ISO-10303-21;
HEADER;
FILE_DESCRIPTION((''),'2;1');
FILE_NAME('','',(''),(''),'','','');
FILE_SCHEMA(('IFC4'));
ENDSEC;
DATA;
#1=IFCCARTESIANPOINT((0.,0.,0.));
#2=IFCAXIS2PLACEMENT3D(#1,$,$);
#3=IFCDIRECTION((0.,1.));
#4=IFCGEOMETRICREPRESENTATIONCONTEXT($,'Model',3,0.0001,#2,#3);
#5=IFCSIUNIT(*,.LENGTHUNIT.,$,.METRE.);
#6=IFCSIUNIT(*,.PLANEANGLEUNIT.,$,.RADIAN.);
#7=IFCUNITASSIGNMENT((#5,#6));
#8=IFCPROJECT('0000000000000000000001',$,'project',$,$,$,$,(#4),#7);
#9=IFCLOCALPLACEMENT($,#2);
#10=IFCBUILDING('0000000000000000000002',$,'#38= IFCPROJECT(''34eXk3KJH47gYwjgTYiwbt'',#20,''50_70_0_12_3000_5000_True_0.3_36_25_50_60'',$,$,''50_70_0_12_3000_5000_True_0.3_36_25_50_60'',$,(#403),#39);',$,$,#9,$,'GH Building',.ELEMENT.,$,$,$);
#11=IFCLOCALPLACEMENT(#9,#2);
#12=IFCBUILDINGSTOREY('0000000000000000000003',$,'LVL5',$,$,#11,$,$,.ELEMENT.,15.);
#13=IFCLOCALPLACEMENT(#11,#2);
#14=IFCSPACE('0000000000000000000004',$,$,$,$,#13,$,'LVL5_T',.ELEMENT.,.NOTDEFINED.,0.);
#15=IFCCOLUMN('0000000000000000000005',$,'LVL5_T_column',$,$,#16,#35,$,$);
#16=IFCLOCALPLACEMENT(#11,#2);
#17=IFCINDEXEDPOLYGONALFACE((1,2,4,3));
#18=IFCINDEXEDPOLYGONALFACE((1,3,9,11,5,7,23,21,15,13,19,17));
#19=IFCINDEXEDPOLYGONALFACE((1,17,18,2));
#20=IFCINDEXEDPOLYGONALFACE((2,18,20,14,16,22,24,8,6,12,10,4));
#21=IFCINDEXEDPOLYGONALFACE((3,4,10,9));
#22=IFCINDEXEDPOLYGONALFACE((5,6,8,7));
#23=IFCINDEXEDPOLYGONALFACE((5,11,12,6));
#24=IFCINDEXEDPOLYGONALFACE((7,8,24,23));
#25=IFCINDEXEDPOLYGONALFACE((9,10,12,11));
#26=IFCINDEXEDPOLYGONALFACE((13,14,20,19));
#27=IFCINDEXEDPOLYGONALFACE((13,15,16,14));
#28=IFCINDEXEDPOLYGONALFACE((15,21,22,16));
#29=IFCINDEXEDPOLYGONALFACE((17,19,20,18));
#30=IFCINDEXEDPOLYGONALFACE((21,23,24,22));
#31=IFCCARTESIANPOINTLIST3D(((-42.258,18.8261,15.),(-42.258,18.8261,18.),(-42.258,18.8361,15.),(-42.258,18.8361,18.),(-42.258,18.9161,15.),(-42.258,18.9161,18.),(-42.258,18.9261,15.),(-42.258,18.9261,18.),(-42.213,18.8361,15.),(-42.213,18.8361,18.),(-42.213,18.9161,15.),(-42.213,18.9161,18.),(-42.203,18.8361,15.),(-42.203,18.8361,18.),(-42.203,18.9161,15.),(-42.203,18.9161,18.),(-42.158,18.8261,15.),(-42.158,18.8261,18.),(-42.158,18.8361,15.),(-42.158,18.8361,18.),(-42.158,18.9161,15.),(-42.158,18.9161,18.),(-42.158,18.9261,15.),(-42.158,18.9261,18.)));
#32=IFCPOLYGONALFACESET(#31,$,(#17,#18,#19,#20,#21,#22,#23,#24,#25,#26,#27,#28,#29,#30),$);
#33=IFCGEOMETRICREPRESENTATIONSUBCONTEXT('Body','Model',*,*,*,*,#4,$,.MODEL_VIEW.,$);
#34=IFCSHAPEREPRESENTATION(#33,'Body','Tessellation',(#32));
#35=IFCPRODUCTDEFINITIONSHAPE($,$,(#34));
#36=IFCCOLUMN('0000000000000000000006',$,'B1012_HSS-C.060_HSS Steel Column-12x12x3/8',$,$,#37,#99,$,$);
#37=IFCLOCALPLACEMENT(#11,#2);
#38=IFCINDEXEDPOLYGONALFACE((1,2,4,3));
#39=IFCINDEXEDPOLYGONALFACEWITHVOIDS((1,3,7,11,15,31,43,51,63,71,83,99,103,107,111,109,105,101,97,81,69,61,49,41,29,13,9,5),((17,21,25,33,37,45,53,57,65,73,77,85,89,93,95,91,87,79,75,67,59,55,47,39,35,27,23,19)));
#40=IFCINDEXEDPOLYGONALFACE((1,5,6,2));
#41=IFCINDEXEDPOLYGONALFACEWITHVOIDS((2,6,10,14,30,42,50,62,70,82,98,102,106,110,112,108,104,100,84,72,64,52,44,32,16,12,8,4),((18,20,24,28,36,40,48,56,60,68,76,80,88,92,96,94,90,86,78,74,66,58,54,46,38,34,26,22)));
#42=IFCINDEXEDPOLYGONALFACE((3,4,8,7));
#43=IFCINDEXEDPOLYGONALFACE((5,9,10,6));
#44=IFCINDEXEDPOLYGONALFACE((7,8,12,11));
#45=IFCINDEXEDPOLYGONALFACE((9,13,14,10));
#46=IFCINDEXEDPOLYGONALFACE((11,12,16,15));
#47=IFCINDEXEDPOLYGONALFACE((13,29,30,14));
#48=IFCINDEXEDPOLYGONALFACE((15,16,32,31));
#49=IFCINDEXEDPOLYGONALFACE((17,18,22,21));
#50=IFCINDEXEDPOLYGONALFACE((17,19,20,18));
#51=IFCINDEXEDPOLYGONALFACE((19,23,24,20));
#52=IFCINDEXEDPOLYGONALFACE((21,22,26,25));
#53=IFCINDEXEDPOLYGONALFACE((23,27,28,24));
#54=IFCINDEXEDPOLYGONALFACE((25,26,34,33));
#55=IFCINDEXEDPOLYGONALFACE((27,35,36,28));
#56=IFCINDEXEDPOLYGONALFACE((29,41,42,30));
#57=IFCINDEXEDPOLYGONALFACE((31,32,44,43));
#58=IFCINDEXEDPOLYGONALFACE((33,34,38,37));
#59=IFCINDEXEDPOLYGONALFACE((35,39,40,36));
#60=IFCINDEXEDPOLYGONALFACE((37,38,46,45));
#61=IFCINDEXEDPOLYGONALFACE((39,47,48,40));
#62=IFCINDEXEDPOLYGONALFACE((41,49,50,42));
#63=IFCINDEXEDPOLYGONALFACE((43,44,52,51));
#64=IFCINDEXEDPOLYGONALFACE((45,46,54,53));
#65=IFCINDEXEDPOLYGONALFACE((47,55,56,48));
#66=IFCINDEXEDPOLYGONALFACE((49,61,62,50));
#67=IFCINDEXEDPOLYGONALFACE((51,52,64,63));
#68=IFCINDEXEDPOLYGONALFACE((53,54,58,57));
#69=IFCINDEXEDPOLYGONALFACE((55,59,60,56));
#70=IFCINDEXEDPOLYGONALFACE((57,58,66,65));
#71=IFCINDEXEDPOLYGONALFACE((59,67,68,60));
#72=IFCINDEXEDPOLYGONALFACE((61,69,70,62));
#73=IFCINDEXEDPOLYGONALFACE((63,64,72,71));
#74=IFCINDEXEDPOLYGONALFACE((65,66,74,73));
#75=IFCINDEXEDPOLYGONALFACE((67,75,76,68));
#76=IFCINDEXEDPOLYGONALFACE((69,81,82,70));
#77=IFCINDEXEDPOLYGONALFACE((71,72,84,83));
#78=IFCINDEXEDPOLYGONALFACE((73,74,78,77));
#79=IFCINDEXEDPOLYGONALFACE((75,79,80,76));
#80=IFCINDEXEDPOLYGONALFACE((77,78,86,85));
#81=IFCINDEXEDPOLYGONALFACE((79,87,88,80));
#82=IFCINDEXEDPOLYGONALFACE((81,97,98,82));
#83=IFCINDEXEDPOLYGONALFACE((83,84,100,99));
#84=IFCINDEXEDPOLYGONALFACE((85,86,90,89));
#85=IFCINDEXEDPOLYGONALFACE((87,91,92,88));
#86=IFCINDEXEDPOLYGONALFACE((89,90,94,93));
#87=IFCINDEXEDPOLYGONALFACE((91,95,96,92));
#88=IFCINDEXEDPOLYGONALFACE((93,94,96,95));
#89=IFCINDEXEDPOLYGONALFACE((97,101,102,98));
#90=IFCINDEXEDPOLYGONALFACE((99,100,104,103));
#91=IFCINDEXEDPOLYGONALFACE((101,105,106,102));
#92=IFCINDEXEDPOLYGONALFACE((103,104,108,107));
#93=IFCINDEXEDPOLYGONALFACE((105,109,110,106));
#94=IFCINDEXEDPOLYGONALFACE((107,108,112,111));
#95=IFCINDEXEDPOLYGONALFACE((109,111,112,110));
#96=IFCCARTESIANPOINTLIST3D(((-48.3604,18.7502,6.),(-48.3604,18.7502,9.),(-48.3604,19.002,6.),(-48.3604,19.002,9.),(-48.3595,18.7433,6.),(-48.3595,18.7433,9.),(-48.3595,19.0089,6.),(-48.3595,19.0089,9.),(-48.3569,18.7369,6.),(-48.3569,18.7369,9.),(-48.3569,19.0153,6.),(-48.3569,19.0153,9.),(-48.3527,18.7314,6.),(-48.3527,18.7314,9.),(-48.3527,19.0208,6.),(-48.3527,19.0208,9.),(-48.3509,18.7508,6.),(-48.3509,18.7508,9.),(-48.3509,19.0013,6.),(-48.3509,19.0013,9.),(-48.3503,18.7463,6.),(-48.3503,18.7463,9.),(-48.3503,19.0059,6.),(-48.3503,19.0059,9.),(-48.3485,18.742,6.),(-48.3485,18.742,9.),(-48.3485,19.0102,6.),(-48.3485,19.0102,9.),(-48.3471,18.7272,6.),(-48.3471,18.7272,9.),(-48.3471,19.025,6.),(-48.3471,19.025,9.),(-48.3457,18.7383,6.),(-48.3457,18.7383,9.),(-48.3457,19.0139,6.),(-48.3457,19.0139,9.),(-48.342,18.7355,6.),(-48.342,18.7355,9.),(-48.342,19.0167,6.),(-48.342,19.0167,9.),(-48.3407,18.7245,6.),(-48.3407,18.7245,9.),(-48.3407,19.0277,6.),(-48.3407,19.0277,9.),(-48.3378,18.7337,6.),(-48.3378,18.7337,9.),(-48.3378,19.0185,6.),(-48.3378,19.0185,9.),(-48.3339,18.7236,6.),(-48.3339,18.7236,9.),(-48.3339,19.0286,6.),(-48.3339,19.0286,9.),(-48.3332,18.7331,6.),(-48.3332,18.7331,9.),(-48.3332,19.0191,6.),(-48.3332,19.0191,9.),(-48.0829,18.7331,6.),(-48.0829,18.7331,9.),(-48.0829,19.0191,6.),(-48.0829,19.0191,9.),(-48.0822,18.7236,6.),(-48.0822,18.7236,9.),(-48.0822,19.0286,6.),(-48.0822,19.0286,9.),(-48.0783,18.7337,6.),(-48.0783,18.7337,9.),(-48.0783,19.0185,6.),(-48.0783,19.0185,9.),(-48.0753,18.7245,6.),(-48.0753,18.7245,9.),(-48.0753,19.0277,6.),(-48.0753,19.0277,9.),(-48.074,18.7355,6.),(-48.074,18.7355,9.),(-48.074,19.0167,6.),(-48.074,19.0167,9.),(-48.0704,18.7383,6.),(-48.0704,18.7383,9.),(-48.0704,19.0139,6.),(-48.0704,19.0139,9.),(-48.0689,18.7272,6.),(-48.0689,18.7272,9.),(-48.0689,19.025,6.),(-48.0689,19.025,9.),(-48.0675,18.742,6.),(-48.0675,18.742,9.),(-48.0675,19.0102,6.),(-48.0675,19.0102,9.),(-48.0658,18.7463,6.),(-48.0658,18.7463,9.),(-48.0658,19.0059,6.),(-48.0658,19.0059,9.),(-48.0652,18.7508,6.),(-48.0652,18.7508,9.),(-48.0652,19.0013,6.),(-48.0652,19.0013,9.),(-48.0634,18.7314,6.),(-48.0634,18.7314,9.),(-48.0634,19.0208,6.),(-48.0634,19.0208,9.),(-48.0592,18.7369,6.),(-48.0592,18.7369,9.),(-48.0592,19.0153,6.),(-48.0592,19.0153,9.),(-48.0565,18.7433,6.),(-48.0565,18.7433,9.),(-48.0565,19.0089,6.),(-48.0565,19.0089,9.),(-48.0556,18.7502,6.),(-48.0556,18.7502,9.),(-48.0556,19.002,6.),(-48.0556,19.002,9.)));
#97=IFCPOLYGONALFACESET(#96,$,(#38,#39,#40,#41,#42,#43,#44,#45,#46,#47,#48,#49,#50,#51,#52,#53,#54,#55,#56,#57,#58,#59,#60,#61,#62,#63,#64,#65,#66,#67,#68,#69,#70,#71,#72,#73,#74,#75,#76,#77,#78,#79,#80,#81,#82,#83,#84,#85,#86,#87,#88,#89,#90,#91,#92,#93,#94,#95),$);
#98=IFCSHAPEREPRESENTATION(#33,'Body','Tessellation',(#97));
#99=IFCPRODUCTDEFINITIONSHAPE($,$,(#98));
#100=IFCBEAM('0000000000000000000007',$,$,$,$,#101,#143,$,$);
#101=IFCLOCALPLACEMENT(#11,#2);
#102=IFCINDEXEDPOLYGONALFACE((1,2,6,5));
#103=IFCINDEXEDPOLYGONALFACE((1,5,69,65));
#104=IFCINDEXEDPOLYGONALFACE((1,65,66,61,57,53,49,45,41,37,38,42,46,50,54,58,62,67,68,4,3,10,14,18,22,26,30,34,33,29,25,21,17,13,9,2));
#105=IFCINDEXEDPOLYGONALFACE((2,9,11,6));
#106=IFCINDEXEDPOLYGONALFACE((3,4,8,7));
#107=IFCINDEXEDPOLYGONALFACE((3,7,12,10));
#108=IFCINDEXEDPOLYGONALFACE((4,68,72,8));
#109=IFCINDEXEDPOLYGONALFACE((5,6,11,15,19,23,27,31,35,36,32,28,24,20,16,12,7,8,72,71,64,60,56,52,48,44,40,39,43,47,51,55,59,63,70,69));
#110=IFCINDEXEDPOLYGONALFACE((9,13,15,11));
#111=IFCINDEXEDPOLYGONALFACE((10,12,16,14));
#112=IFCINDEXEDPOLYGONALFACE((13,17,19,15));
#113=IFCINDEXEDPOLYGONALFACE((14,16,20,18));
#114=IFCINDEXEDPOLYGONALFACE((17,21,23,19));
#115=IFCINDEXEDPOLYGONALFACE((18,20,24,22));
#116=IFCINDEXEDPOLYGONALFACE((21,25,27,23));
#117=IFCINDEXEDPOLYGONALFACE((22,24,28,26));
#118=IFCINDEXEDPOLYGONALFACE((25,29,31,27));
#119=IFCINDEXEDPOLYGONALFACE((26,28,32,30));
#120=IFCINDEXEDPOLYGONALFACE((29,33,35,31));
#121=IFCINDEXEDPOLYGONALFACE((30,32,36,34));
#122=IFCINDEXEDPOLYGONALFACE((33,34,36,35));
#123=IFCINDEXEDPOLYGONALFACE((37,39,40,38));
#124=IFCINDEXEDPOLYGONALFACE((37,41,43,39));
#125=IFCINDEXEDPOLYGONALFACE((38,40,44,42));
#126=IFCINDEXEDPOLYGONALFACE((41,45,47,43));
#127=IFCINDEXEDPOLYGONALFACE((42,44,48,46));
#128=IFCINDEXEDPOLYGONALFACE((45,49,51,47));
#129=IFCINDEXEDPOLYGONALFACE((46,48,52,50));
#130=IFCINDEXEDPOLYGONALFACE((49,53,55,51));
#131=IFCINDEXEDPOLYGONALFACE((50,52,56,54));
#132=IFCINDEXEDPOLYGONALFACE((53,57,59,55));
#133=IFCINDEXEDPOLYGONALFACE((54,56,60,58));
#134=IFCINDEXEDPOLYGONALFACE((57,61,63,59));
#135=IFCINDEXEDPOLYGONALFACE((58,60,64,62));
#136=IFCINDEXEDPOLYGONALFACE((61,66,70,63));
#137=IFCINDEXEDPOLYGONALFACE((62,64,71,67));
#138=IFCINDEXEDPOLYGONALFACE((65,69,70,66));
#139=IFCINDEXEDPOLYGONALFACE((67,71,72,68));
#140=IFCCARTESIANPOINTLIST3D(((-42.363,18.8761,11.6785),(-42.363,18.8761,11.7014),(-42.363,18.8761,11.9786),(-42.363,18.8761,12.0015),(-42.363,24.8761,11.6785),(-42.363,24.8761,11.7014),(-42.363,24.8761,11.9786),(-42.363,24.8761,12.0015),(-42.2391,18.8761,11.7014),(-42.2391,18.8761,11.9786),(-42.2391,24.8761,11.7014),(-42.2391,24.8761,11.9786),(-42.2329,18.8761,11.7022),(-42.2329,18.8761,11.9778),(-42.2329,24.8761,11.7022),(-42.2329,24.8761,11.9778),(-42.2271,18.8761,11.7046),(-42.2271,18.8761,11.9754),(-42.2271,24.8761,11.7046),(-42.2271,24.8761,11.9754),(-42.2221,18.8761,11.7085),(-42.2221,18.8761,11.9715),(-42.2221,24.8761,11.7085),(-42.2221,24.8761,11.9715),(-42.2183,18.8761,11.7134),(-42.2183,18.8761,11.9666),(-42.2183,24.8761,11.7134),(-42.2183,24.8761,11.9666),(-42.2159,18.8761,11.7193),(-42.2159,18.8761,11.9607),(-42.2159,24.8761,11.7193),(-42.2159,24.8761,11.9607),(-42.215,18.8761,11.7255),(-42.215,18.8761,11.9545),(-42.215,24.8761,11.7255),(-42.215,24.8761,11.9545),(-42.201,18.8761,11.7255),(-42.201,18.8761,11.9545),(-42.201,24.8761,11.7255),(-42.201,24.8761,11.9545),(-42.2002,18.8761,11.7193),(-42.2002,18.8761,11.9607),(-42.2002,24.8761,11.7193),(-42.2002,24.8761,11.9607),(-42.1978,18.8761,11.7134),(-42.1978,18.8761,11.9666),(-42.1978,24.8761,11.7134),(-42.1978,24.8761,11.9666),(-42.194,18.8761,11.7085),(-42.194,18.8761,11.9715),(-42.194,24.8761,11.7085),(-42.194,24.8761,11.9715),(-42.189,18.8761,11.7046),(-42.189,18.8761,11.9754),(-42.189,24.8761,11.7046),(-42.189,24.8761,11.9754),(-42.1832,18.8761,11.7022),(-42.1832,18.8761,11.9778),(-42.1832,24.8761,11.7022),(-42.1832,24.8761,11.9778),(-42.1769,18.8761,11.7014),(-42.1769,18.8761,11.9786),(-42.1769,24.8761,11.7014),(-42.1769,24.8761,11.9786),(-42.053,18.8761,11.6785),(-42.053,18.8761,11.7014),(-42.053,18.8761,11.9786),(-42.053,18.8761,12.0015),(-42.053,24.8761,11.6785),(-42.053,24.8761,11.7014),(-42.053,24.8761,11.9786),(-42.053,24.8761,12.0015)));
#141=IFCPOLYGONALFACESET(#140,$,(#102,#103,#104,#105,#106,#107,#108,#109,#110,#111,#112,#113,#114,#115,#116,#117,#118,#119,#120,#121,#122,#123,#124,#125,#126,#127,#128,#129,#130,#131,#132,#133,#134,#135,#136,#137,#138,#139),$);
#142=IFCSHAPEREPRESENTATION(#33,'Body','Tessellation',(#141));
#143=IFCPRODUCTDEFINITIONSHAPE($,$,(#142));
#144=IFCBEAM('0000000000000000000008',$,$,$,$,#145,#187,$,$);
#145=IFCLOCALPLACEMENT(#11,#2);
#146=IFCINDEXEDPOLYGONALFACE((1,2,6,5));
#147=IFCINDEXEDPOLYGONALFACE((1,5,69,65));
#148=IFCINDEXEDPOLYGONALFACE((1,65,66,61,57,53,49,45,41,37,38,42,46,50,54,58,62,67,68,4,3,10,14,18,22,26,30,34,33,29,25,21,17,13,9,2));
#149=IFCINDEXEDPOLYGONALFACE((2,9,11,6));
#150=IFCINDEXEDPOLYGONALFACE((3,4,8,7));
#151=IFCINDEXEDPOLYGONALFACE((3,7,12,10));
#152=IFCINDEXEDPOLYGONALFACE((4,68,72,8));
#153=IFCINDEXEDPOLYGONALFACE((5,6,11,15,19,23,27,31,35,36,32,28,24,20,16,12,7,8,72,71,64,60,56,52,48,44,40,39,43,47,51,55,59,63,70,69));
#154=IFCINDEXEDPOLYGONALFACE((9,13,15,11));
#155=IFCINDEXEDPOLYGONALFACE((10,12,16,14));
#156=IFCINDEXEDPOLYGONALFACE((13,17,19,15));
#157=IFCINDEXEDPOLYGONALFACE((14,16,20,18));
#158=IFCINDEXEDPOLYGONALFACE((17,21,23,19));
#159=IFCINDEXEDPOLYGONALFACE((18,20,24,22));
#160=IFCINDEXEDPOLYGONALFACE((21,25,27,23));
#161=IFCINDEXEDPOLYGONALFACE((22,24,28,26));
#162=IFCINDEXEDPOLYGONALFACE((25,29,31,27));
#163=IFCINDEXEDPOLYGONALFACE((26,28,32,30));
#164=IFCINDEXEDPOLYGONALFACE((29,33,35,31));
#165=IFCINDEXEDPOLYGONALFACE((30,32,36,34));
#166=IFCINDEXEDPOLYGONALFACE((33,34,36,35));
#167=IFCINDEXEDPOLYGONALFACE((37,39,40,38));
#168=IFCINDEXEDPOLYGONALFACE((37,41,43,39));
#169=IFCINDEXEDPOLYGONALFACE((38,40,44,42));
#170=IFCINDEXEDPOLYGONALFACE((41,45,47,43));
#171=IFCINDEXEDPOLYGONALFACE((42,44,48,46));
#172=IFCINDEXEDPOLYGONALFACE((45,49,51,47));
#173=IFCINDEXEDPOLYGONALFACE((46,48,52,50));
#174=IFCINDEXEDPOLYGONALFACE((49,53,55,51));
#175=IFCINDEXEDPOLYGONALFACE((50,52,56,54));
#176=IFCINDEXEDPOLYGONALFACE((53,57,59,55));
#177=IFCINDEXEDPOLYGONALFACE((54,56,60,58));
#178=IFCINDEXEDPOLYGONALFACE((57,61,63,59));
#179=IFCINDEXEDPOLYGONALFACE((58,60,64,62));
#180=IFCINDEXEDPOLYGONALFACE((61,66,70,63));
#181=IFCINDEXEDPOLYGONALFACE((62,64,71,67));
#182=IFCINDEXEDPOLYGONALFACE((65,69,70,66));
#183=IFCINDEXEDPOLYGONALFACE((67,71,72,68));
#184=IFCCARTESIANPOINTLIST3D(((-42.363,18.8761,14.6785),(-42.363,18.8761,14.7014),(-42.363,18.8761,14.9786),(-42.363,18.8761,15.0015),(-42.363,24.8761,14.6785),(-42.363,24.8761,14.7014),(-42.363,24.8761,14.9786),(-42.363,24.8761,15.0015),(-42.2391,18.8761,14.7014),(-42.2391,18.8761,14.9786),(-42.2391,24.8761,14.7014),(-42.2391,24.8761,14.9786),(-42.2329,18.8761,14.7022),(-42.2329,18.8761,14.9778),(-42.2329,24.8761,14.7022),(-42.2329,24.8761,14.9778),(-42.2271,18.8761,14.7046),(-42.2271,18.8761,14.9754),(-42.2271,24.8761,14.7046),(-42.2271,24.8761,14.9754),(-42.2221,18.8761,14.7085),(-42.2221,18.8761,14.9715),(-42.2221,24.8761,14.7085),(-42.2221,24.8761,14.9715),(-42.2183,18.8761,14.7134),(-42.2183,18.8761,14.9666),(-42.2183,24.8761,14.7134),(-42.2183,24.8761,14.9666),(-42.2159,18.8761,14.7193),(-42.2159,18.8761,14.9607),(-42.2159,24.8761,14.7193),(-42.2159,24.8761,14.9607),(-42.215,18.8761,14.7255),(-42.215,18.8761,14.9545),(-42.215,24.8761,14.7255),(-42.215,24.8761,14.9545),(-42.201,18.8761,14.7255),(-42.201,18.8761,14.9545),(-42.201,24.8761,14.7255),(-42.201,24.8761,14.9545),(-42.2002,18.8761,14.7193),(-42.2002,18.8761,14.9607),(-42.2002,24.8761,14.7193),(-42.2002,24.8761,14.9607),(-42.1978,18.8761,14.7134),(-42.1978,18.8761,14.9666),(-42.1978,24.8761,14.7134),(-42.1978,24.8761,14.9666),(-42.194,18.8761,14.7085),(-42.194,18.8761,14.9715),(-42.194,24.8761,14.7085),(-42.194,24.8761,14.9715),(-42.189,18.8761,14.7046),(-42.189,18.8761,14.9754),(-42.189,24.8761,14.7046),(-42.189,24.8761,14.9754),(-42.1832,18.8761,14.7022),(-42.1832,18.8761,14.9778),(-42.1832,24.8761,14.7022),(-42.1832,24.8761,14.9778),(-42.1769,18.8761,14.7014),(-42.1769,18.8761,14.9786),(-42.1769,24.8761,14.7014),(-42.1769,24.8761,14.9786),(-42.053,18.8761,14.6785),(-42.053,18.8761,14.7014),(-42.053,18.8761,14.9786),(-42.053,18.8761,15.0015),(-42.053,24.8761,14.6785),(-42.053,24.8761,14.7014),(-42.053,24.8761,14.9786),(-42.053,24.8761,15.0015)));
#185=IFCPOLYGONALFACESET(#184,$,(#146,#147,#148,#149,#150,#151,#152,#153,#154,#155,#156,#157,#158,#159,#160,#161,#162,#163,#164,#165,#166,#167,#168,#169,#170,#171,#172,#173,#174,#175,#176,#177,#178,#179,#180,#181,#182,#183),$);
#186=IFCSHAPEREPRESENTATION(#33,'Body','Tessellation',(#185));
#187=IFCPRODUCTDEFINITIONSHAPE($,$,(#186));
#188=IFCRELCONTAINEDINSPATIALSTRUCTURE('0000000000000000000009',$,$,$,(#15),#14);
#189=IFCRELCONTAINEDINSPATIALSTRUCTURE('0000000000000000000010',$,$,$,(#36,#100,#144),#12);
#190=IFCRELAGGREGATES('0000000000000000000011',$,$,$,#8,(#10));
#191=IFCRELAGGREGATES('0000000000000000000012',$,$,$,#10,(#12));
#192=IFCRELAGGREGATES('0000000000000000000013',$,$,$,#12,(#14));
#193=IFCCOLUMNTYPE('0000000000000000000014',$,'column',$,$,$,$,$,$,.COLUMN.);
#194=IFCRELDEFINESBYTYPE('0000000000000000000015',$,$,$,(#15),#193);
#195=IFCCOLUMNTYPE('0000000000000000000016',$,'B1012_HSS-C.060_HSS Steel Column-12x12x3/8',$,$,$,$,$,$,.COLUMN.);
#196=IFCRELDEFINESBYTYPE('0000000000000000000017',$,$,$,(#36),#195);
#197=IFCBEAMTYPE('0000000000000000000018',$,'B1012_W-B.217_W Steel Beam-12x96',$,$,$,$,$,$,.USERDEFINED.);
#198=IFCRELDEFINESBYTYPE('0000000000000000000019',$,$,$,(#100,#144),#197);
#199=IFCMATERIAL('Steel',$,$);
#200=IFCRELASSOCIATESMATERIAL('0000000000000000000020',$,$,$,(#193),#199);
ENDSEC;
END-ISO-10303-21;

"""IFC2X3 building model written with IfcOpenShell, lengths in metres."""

from ifc_helpers import new_model, si_unit, direction, frame, origin, origin_2d, place, context, subcontext, project, spatial, hollow_rectangle, i_section, extrude, material, type_object, element, save


model = new_model("IFC2X3")

# Units and contexts
model_context = context("Model", 3, precision=0.0001, world=origin(), true_north=direction((0.0, 1.0)))
body_context = subcontext(model_context, "Body", "Model", "MODEL_VIEW")
ifc_project = project(units=[si_unit("LENGTHUNIT", "METRE"), si_unit("PLANEANGLEUNIT", "RADIAN")], contexts=[model_context])

# Building, storey, space
building_placement = place(None, origin())
building = spatial("IfcBuilding", under=ifc_project, at=building_placement, Name="#38= IFCPROJECT('34eXk3KJH47gYwjgTYiwbt',#20,'50_70_0_12_3000_5000_True_0.3_36_25_50_60',$,$,'50_70_0_12_3000_5000_True_0.3_36_25_50_60',$,(#403),#39);", LongName="GH Building", CompositionType="ELEMENT")
storey_placement = place(building_placement, origin())
storey = spatial("IfcBuildingStorey", under=building, at=storey_placement, Name="LVL5", CompositionType="ELEMENT", Elevation=15.0)
space_1_placement = place(storey_placement, origin())
space_1 = spatial("IfcSpace", under=storey, at=space_1_placement, LongName="LVL5_T", CompositionType="ELEMENT", InteriorOrExteriorSpace="NOTDEFINED", ElevationWithFlooring=0.0)

# Column
ifc_material_1 = material(Name="Steel")
column_type_1 = type_object("IfcColumnType", Name="column", PredefinedType="COLUMN", material=ifc_material_1)
for number, where, name in (
    (1, (-42.208, 18.8761, 15.0), "LVL5_T_column"),
):
    element("IfcColumn", number, at=place(space_1_placement, frame(where)), inside=space_1, type_object=column_type_1, Name=name, context=body_context, shape_type="SweptSolid", body=[
        extrude(i_section(OverallWidth=0.1, OverallDepth=0.1, WebThickness=0.01, FlangeThickness=0.01, at=origin_2d()), origin(), (0.0, 0.0, 1.0), 3.0),
    ])

# Column
column_type_2 = type_object("IfcColumnType", Name="B1012_HSS-C.060_HSS Steel Column-12x12x3/8", PredefinedType="COLUMN")
column_placement = place(storey_placement, frame((-48.208, 18.8761, 9.0), z_axis=(0.0, 0.0, -1.0), x_axis=(-1.0, 0.0, 0.0)))
element("IfcColumn", 2, at=column_placement, inside=storey, type_object=column_type_2, Name="B1012_HSS-C.060_HSS Steel Column-12x12x3/8", context=body_context, shape_type="SweptSolid", body=[
    extrude(hollow_rectangle(XDim=0.3048, YDim=0.305, WallThickness=0.0095, InnerFilletRadius=0.0177, OuterFilletRadius=0.0266, at=origin_2d()), origin(), (0.0, 0.0, 1.0), 3.0),
])

# Beams
beam_type = type_object("IfcBeamType", Name="B1012_W-B.217_W Steel Beam-12x96", PredefinedType="USERDEFINED")
for number, where, z_axis, x_axis in (
    (3, (-42.208, 18.8761, 11.84), (0.0, 1.0, 0.0), (-1.0, 0.0, 0.0)),
    (4, (-42.208, 18.8761, 14.84), (0.0, 1.0, 0.0), (-1.0, 0.0, 0.0)),
):
    element("IfcBeam", number, at=place(storey_placement, frame(where, z_axis=z_axis, x_axis=x_axis)), inside=storey, type_object=beam_type, context=body_context, shape_type="SweptSolid", body=[
        extrude(i_section(OverallWidth=0.31, OverallDepth=0.323, WebThickness=0.014, FlangeThickness=0.0229, FilletRadius=0.0241, at=origin_2d()), origin(), (0.0, 0.0, 1.0), 6.0),
    ])

save(model, "model.ifc")
